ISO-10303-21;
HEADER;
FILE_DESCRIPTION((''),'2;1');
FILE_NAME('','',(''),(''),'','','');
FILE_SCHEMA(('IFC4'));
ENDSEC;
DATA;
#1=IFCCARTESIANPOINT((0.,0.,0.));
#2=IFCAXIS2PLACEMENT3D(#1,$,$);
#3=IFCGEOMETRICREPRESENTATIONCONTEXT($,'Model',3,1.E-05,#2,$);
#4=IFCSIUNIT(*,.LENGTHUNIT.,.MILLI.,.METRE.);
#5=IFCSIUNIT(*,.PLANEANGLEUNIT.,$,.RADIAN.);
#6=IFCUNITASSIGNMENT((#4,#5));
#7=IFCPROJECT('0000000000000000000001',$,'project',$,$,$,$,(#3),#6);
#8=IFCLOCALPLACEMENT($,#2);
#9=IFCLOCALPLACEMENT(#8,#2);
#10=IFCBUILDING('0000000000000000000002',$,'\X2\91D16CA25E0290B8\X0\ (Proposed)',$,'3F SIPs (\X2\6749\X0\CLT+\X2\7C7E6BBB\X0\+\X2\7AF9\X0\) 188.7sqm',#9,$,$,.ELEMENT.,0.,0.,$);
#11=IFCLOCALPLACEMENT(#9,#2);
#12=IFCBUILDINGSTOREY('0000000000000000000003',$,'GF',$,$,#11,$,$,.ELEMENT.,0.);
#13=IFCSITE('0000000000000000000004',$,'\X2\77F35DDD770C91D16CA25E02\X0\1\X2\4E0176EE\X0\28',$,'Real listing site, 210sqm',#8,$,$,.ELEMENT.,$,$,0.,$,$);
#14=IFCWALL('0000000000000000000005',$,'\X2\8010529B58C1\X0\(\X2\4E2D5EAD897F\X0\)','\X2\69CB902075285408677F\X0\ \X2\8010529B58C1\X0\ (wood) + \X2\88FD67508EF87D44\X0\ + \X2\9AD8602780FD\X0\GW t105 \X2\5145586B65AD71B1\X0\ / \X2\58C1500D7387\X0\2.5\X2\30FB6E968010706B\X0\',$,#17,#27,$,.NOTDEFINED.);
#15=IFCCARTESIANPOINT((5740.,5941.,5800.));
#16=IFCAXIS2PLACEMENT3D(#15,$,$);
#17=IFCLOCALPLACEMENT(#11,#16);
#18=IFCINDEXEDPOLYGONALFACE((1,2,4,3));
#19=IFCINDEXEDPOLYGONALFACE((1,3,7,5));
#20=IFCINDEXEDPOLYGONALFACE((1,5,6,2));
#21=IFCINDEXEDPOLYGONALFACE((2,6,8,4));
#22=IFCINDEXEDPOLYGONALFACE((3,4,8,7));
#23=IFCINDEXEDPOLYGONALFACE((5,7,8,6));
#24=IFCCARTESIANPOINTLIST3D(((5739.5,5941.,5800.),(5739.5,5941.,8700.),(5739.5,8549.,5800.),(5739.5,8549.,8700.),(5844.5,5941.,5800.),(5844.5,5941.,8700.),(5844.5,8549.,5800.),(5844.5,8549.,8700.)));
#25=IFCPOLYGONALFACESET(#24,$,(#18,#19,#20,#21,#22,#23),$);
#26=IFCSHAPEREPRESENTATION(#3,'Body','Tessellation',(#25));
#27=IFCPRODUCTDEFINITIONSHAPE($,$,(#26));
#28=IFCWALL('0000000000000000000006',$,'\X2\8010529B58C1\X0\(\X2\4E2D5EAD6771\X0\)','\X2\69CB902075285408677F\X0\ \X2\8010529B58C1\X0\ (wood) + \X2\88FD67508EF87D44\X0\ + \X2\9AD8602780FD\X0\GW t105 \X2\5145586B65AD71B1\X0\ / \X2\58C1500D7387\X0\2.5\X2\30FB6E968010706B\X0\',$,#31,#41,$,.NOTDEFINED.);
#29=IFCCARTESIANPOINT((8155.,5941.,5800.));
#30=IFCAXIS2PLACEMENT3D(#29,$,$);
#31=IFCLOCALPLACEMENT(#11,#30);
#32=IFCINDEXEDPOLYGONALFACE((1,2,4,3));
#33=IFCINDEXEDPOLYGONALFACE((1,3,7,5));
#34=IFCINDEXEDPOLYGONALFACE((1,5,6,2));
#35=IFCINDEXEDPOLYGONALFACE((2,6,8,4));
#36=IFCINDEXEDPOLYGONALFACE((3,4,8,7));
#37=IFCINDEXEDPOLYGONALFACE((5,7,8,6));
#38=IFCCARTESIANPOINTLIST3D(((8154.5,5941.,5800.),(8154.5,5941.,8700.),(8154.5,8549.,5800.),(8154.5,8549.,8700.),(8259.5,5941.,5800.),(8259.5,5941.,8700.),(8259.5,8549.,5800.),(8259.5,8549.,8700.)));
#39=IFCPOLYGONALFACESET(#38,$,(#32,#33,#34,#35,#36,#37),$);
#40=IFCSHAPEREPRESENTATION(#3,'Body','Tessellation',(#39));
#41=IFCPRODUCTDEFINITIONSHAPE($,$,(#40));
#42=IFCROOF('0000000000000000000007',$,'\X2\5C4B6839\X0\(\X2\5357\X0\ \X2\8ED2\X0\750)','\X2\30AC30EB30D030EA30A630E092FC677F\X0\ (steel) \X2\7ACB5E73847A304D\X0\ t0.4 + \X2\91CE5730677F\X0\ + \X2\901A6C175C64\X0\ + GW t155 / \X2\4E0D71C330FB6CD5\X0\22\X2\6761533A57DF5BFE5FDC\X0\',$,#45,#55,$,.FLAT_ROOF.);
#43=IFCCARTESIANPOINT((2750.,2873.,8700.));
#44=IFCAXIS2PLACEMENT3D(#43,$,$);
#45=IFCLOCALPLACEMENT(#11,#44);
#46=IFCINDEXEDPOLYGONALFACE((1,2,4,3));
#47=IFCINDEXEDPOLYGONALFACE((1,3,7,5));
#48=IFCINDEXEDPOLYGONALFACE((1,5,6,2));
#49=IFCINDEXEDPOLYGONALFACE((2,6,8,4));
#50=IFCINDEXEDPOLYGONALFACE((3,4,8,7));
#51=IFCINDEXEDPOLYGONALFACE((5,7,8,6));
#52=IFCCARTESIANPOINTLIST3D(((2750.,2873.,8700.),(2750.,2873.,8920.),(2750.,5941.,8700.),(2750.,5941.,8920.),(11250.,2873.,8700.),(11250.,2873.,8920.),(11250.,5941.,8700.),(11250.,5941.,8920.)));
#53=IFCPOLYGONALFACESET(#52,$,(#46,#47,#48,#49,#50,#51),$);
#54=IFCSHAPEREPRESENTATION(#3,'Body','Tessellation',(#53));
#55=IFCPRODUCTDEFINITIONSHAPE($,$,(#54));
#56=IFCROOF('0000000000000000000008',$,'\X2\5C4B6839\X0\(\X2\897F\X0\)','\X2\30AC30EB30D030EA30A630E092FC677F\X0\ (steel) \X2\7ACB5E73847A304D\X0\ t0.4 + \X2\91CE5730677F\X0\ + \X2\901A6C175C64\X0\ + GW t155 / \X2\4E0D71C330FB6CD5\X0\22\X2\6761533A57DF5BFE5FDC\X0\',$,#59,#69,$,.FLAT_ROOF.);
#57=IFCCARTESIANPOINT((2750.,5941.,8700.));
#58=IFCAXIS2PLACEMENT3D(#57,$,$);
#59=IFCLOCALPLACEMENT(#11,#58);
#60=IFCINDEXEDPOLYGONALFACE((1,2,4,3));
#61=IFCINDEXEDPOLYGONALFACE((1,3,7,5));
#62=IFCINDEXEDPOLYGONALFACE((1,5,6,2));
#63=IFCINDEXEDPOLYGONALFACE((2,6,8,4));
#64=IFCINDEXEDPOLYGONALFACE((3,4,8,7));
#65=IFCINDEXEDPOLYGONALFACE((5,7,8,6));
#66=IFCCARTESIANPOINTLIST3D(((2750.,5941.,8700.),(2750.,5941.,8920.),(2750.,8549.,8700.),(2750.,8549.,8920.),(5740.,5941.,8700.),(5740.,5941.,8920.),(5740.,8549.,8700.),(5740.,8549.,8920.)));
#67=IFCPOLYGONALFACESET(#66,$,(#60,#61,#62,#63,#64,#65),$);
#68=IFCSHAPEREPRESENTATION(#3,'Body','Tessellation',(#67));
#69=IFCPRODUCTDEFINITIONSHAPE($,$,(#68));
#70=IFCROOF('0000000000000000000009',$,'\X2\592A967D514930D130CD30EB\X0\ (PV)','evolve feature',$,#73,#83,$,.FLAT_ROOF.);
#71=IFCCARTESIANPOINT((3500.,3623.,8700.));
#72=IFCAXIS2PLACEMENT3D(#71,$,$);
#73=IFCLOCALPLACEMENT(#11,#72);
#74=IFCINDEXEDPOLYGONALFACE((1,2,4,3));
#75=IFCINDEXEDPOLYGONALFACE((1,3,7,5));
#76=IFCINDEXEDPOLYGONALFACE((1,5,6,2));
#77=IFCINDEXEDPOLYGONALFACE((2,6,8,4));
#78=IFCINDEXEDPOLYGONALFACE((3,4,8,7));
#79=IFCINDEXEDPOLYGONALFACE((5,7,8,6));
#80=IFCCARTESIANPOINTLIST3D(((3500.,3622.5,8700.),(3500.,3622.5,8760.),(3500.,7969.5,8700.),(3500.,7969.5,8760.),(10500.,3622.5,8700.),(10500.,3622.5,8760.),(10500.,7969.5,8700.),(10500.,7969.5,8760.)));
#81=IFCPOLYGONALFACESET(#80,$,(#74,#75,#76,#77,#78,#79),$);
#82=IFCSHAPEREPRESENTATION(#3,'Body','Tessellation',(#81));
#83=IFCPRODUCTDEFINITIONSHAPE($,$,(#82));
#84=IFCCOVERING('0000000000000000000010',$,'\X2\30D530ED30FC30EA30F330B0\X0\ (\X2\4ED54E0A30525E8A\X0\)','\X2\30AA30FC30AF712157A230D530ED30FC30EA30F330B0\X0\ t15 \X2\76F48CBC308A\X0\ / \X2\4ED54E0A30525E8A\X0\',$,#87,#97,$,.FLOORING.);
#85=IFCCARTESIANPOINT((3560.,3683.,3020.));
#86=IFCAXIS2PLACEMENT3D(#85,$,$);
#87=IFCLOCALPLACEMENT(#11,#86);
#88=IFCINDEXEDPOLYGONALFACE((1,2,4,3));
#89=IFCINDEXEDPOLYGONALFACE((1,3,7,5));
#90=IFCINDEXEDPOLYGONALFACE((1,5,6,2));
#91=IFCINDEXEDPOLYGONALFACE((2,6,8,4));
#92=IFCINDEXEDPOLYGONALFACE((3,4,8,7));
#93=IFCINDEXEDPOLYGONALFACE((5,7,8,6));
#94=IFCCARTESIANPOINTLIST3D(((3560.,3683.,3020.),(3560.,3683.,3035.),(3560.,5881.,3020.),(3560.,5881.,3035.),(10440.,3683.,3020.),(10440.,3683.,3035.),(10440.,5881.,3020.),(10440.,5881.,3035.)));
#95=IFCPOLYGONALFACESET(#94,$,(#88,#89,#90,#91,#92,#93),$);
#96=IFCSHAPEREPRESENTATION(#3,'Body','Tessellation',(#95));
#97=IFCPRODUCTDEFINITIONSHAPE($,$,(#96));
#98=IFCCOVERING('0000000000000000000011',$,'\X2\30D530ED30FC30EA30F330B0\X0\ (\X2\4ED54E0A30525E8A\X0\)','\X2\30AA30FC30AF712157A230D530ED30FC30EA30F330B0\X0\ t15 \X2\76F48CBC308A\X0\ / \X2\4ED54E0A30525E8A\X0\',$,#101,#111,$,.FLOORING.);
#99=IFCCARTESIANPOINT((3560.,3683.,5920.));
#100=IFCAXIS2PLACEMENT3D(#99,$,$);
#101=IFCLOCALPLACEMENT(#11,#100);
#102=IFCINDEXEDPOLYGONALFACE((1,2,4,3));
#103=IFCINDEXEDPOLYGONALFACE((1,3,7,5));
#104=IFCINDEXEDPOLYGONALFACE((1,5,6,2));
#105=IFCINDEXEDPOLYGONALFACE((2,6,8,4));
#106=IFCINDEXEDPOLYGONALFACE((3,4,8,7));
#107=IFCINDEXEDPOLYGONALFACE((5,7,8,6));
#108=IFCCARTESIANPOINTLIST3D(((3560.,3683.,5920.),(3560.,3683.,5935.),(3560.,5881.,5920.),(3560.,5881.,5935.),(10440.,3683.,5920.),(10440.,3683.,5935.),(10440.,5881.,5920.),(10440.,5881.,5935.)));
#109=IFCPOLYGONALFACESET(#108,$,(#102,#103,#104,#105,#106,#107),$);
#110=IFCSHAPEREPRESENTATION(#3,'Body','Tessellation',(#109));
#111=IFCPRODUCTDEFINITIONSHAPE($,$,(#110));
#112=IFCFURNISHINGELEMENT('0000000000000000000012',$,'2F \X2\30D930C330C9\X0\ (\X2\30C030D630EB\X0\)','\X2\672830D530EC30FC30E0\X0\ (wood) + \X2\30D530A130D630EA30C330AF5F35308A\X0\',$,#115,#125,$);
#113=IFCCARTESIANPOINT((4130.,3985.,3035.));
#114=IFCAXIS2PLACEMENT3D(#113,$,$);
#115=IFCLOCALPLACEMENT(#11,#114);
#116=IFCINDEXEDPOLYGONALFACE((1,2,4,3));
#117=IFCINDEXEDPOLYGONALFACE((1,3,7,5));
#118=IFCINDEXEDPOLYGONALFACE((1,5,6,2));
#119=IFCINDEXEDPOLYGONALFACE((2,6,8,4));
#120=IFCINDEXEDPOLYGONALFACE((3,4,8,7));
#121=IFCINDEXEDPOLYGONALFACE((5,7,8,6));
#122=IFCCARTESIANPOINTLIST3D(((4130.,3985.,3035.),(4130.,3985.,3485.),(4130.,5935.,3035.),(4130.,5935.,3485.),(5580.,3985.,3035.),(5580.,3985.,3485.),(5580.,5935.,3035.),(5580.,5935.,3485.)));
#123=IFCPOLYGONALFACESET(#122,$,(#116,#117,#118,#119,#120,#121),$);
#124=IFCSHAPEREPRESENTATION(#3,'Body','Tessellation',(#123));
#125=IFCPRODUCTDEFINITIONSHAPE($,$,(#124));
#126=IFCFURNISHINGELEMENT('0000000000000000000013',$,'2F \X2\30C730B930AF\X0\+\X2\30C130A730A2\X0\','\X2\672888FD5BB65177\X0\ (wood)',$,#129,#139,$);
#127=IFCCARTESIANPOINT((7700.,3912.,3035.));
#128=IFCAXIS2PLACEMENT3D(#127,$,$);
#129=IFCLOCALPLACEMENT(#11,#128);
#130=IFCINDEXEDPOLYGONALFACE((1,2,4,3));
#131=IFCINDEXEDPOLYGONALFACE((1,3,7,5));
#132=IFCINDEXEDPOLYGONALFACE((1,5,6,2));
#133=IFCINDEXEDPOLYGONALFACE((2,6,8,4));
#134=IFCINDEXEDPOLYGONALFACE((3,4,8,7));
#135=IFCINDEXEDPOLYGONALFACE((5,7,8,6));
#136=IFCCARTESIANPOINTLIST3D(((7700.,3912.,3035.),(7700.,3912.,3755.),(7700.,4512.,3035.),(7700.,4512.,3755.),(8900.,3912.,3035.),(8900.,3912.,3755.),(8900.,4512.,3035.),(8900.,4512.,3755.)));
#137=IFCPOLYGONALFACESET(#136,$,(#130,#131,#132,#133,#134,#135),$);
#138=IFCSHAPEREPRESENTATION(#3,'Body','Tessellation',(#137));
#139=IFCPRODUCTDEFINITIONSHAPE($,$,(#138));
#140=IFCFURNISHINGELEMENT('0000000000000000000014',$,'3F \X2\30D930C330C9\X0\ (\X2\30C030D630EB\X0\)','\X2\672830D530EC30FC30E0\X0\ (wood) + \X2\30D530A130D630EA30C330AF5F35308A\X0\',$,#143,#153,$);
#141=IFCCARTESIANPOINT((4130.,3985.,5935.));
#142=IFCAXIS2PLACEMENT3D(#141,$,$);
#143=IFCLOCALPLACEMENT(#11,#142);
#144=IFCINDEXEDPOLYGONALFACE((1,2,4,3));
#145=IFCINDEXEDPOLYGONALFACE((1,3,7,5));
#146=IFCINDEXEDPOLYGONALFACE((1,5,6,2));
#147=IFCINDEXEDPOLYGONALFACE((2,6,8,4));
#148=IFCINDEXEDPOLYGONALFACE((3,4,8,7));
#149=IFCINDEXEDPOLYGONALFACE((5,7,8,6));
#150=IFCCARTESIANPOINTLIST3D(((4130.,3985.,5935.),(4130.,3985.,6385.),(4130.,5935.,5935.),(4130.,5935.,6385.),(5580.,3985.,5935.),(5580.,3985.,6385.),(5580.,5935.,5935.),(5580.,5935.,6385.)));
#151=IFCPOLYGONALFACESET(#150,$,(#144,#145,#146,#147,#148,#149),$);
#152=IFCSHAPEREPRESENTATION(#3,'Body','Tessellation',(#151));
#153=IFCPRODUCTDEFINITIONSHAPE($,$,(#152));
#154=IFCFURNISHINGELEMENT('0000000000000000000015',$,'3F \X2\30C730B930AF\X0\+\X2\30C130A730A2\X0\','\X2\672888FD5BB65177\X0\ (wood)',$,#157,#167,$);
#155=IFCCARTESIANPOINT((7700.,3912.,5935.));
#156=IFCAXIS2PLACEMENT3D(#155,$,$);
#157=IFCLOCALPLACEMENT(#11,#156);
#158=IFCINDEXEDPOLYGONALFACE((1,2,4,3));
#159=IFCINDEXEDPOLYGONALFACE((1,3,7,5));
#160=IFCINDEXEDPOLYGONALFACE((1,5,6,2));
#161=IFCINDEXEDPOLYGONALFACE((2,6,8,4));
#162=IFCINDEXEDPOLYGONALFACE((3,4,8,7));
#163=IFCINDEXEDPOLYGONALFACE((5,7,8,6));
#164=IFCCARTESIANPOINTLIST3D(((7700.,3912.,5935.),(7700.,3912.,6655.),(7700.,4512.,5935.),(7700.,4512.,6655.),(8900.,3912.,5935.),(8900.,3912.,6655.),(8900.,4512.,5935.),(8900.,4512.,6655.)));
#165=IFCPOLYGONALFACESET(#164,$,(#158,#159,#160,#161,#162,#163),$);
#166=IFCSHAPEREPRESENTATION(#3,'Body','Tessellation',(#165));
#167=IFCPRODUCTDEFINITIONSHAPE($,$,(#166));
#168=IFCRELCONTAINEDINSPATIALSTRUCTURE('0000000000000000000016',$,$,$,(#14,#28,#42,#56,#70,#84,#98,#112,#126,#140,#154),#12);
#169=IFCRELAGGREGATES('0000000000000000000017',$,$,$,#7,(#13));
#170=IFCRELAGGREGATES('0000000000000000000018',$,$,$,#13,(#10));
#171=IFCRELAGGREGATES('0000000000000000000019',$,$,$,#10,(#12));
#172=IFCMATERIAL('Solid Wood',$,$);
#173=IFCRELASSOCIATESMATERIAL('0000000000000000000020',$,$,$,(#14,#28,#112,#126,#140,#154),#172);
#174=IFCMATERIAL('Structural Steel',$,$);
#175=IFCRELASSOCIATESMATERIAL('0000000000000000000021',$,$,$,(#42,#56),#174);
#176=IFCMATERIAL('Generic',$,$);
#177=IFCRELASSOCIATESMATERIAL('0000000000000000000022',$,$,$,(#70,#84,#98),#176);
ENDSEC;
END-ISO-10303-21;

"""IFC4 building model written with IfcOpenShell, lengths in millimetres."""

from ifc_helpers import new_model, si_unit, frame, frame_2d, origin, place, context, project, spatial, rectangle, extrude, material, element, save


model = new_model("IFC4")

# Units and contexts
model_context = context("Model", 3, precision=1e-05, world=origin())
ifc_project = project(units=[si_unit("LENGTHUNIT", "METRE", prefix="MILLI"), si_unit("PLANEANGLEUNIT", "RADIAN")], contexts=[model_context])

# Site, building, storey
site_placement = place(None, origin())
site = spatial("IfcSite", under=ifc_project, at=site_placement, Name="石川県金沢市1丁目28", ObjectType="Real listing site, 210sqm", CompositionType="ELEMENT", RefElevation=0.0)
building_placement = place(site_placement, origin())
building = spatial("IfcBuilding", under=site, at=building_placement, Name="金沢市邸 (Proposed)", ObjectType="3F SIPs (杉CLT+籾殻+竹) 188.7sqm", CompositionType="ELEMENT", ElevationOfRefHeight=0.0, ElevationOfTerrain=0.0)
storey_placement = place(building_placement, origin())
storey = spatial("IfcBuildingStorey", under=building, at=storey_placement, Name="GF", CompositionType="ELEMENT", Elevation=0.0)

# Shared definitions
ifc_material_1 = material(Name="Solid Wood")

# Walls
wall_1_placement = place(storey_placement, frame((5740.0, 5941.0, 5800.0)))
element("IfcWall", 1, at=wall_1_placement, inside=storey, material=ifc_material_1, Name="耐力壁(中庭西)", Description="構造用合板 耐力壁 (wood) + 製材軸組 + 高性能GW t105 充填断熱 / 壁倍率2.5・準耐火", PredefinedType="NOTDEFINED", context=model_context, shape_type="SweptSolid", body=[
    extrude(rectangle(XDim=105.0, YDim=2608.0, at=frame_2d((52.0, 1304.0))), frame((5740.0, 5941.0, 5800.0)), (0.0, 0.0, 1.0), 2900.0),
])
wall_2_placement = place(storey_placement, frame((8155.0, 5941.0, 5800.0)))
element("IfcWall", 2, at=wall_2_placement, inside=storey, material=ifc_material_1, Name="耐力壁(中庭東)", Description="構造用合板 耐力壁 (wood) + 製材軸組 + 高性能GW t105 充填断熱 / 壁倍率2.5・準耐火", PredefinedType="NOTDEFINED", context=model_context, shape_type="SweptSolid", body=[
    extrude(rectangle(XDim=105.0, YDim=2608.0, at=frame_2d((52.0, 1304.0))), frame((8155.0, 5941.0, 5800.0)), (0.0, 0.0, 1.0), 2900.0),
])

# Roofs
ifc_material_2 = material(Name="Structural Steel")
roof_1_placement = place(storey_placement, frame((2750.0, 2873.0, 8700.0)))
element("IfcRoof", 3, at=roof_1_placement, inside=storey, material=ifc_material_2, Name="屋根(南 軒750)", Description="ガルバリウム鋼板 (steel) 立平葺き t0.4 + 野地板 + 通気層 + GW t155 / 不燃・法22条区域対応", PredefinedType="FLAT_ROOF", context=model_context, shape_type="SweptSolid", body=[
    extrude(rectangle(XDim=8500.0, YDim=3068.0, at=frame_2d((4250.0, 1534.0))), frame((2750.0, 2873.0, 8700.0)), (0.0, 0.0, 1.0), 220.0),
])
roof_2_placement = place(storey_placement, frame((2750.0, 5941.0, 8700.0)))
element("IfcRoof", 4, at=roof_2_placement, inside=storey, material=ifc_material_2, Name="屋根(西)", Description="ガルバリウム鋼板 (steel) 立平葺き t0.4 + 野地板 + 通気層 + GW t155 / 不燃・法22条区域対応", PredefinedType="FLAT_ROOF", context=model_context, shape_type="SweptSolid", body=[
    extrude(rectangle(XDim=2990.0, YDim=2608.0, at=frame_2d((1495.0, 1304.0))), frame((2750.0, 5941.0, 8700.0)), (0.0, 0.0, 1.0), 220.0),
])
ifc_material_3 = material(Name="Generic")
roof_3_placement = place(storey_placement, frame((3500.0, 3623.0, 8700.0)))
element("IfcRoof", 5, at=roof_3_placement, inside=storey, material=ifc_material_3, Name="太陽光パネル (PV)", Description="evolve feature", PredefinedType="FLAT_ROOF", context=model_context, shape_type="SweptSolid", body=[
    extrude(rectangle(XDim=7000.0, YDim=4347.0, at=frame_2d((3500.0, 2173.0))), frame((3500.0, 3623.0, 8700.0)), (0.0, 0.0, 1.0), 60.0),
])

# Coverings
covering_1_placement = place(storey_placement, frame((3560.0, 3683.0, 3020.0)))
element("IfcCovering", 6, at=covering_1_placement, inside=storey, material=ifc_material_3, Name="フローリング (仕上げ床)", Description="オーク無垢フローリング t15 直貼り / 仕上げ床", PredefinedType="FLOORING", context=model_context, shape_type="SweptSolid", body=[
    extrude(rectangle(XDim=6880.0, YDim=2198.0, at=frame_2d((3440.0, 1099.0))), frame((3560.0, 3683.0, 3020.0)), (0.0, 0.0, 1.0), 15.0),
])
covering_2_placement = place(storey_placement, frame((3560.0, 3683.0, 5920.0)))
element("IfcCovering", 7, at=covering_2_placement, inside=storey, material=ifc_material_3, Name="フローリング (仕上げ床)", Description="オーク無垢フローリング t15 直貼り / 仕上げ床", PredefinedType="FLOORING", context=model_context, shape_type="SweptSolid", body=[
    extrude(rectangle(XDim=6880.0, YDim=2198.0, at=frame_2d((3440.0, 1099.0))), frame((3560.0, 3683.0, 5920.0)), (0.0, 0.0, 1.0), 15.0),
])

# Furnishing elements
furnishing_1_placement = place(storey_placement, frame((4130.0, 3985.0, 3035.0)))
element("IfcFurnishingElement", 8, at=furnishing_1_placement, inside=storey, material=ifc_material_1, Name="2F ベッド (ダブル)", Description="木フレーム (wood) + ファブリック張り", context=model_context, shape_type="SweptSolid", body=[
    extrude(rectangle(XDim=1450.0, YDim=1950.0, at=frame_2d((725.0, 975.0))), frame((4130.0, 3985.0, 3035.0)), (0.0, 0.0, 1.0), 450.0),
])
furnishing_2_placement = place(storey_placement, frame((7700.0, 3912.0, 3035.0)))
element("IfcFurnishingElement", 9, at=furnishing_2_placement, inside=storey, material=ifc_material_1, Name="2F デスク+チェア", Description="木製家具 (wood)", context=model_context, shape_type="SweptSolid", body=[
    extrude(rectangle(XDim=1200.0, YDim=600.0, at=frame_2d((600.0, 300.0))), frame((7700.0, 3912.0, 3035.0)), (0.0, 0.0, 1.0), 720.0),
])
furnishing_3_placement = place(storey_placement, frame((4130.0, 3985.0, 5935.0)))
element("IfcFurnishingElement", 10, at=furnishing_3_placement, inside=storey, material=ifc_material_1, Name="3F ベッド (ダブル)", Description="木フレーム (wood) + ファブリック張り", context=model_context, shape_type="SweptSolid", body=[
    extrude(rectangle(XDim=1450.0, YDim=1950.0, at=frame_2d((725.0, 975.0))), frame((4130.0, 3985.0, 5935.0)), (0.0, 0.0, 1.0), 450.0),
])
furnishing_4_placement = place(storey_placement, frame((7700.0, 3912.0, 5935.0)))
element("IfcFurnishingElement", 11, at=furnishing_4_placement, inside=storey, material=ifc_material_1, Name="3F デスク+チェア", Description="木製家具 (wood)", context=model_context, shape_type="SweptSolid", body=[
    extrude(rectangle(XDim=1200.0, YDim=600.0, at=frame_2d((600.0, 300.0))), frame((7700.0, 3912.0, 5935.0)), (0.0, 0.0, 1.0), 720.0),
])

save(model, "model.ifc")
